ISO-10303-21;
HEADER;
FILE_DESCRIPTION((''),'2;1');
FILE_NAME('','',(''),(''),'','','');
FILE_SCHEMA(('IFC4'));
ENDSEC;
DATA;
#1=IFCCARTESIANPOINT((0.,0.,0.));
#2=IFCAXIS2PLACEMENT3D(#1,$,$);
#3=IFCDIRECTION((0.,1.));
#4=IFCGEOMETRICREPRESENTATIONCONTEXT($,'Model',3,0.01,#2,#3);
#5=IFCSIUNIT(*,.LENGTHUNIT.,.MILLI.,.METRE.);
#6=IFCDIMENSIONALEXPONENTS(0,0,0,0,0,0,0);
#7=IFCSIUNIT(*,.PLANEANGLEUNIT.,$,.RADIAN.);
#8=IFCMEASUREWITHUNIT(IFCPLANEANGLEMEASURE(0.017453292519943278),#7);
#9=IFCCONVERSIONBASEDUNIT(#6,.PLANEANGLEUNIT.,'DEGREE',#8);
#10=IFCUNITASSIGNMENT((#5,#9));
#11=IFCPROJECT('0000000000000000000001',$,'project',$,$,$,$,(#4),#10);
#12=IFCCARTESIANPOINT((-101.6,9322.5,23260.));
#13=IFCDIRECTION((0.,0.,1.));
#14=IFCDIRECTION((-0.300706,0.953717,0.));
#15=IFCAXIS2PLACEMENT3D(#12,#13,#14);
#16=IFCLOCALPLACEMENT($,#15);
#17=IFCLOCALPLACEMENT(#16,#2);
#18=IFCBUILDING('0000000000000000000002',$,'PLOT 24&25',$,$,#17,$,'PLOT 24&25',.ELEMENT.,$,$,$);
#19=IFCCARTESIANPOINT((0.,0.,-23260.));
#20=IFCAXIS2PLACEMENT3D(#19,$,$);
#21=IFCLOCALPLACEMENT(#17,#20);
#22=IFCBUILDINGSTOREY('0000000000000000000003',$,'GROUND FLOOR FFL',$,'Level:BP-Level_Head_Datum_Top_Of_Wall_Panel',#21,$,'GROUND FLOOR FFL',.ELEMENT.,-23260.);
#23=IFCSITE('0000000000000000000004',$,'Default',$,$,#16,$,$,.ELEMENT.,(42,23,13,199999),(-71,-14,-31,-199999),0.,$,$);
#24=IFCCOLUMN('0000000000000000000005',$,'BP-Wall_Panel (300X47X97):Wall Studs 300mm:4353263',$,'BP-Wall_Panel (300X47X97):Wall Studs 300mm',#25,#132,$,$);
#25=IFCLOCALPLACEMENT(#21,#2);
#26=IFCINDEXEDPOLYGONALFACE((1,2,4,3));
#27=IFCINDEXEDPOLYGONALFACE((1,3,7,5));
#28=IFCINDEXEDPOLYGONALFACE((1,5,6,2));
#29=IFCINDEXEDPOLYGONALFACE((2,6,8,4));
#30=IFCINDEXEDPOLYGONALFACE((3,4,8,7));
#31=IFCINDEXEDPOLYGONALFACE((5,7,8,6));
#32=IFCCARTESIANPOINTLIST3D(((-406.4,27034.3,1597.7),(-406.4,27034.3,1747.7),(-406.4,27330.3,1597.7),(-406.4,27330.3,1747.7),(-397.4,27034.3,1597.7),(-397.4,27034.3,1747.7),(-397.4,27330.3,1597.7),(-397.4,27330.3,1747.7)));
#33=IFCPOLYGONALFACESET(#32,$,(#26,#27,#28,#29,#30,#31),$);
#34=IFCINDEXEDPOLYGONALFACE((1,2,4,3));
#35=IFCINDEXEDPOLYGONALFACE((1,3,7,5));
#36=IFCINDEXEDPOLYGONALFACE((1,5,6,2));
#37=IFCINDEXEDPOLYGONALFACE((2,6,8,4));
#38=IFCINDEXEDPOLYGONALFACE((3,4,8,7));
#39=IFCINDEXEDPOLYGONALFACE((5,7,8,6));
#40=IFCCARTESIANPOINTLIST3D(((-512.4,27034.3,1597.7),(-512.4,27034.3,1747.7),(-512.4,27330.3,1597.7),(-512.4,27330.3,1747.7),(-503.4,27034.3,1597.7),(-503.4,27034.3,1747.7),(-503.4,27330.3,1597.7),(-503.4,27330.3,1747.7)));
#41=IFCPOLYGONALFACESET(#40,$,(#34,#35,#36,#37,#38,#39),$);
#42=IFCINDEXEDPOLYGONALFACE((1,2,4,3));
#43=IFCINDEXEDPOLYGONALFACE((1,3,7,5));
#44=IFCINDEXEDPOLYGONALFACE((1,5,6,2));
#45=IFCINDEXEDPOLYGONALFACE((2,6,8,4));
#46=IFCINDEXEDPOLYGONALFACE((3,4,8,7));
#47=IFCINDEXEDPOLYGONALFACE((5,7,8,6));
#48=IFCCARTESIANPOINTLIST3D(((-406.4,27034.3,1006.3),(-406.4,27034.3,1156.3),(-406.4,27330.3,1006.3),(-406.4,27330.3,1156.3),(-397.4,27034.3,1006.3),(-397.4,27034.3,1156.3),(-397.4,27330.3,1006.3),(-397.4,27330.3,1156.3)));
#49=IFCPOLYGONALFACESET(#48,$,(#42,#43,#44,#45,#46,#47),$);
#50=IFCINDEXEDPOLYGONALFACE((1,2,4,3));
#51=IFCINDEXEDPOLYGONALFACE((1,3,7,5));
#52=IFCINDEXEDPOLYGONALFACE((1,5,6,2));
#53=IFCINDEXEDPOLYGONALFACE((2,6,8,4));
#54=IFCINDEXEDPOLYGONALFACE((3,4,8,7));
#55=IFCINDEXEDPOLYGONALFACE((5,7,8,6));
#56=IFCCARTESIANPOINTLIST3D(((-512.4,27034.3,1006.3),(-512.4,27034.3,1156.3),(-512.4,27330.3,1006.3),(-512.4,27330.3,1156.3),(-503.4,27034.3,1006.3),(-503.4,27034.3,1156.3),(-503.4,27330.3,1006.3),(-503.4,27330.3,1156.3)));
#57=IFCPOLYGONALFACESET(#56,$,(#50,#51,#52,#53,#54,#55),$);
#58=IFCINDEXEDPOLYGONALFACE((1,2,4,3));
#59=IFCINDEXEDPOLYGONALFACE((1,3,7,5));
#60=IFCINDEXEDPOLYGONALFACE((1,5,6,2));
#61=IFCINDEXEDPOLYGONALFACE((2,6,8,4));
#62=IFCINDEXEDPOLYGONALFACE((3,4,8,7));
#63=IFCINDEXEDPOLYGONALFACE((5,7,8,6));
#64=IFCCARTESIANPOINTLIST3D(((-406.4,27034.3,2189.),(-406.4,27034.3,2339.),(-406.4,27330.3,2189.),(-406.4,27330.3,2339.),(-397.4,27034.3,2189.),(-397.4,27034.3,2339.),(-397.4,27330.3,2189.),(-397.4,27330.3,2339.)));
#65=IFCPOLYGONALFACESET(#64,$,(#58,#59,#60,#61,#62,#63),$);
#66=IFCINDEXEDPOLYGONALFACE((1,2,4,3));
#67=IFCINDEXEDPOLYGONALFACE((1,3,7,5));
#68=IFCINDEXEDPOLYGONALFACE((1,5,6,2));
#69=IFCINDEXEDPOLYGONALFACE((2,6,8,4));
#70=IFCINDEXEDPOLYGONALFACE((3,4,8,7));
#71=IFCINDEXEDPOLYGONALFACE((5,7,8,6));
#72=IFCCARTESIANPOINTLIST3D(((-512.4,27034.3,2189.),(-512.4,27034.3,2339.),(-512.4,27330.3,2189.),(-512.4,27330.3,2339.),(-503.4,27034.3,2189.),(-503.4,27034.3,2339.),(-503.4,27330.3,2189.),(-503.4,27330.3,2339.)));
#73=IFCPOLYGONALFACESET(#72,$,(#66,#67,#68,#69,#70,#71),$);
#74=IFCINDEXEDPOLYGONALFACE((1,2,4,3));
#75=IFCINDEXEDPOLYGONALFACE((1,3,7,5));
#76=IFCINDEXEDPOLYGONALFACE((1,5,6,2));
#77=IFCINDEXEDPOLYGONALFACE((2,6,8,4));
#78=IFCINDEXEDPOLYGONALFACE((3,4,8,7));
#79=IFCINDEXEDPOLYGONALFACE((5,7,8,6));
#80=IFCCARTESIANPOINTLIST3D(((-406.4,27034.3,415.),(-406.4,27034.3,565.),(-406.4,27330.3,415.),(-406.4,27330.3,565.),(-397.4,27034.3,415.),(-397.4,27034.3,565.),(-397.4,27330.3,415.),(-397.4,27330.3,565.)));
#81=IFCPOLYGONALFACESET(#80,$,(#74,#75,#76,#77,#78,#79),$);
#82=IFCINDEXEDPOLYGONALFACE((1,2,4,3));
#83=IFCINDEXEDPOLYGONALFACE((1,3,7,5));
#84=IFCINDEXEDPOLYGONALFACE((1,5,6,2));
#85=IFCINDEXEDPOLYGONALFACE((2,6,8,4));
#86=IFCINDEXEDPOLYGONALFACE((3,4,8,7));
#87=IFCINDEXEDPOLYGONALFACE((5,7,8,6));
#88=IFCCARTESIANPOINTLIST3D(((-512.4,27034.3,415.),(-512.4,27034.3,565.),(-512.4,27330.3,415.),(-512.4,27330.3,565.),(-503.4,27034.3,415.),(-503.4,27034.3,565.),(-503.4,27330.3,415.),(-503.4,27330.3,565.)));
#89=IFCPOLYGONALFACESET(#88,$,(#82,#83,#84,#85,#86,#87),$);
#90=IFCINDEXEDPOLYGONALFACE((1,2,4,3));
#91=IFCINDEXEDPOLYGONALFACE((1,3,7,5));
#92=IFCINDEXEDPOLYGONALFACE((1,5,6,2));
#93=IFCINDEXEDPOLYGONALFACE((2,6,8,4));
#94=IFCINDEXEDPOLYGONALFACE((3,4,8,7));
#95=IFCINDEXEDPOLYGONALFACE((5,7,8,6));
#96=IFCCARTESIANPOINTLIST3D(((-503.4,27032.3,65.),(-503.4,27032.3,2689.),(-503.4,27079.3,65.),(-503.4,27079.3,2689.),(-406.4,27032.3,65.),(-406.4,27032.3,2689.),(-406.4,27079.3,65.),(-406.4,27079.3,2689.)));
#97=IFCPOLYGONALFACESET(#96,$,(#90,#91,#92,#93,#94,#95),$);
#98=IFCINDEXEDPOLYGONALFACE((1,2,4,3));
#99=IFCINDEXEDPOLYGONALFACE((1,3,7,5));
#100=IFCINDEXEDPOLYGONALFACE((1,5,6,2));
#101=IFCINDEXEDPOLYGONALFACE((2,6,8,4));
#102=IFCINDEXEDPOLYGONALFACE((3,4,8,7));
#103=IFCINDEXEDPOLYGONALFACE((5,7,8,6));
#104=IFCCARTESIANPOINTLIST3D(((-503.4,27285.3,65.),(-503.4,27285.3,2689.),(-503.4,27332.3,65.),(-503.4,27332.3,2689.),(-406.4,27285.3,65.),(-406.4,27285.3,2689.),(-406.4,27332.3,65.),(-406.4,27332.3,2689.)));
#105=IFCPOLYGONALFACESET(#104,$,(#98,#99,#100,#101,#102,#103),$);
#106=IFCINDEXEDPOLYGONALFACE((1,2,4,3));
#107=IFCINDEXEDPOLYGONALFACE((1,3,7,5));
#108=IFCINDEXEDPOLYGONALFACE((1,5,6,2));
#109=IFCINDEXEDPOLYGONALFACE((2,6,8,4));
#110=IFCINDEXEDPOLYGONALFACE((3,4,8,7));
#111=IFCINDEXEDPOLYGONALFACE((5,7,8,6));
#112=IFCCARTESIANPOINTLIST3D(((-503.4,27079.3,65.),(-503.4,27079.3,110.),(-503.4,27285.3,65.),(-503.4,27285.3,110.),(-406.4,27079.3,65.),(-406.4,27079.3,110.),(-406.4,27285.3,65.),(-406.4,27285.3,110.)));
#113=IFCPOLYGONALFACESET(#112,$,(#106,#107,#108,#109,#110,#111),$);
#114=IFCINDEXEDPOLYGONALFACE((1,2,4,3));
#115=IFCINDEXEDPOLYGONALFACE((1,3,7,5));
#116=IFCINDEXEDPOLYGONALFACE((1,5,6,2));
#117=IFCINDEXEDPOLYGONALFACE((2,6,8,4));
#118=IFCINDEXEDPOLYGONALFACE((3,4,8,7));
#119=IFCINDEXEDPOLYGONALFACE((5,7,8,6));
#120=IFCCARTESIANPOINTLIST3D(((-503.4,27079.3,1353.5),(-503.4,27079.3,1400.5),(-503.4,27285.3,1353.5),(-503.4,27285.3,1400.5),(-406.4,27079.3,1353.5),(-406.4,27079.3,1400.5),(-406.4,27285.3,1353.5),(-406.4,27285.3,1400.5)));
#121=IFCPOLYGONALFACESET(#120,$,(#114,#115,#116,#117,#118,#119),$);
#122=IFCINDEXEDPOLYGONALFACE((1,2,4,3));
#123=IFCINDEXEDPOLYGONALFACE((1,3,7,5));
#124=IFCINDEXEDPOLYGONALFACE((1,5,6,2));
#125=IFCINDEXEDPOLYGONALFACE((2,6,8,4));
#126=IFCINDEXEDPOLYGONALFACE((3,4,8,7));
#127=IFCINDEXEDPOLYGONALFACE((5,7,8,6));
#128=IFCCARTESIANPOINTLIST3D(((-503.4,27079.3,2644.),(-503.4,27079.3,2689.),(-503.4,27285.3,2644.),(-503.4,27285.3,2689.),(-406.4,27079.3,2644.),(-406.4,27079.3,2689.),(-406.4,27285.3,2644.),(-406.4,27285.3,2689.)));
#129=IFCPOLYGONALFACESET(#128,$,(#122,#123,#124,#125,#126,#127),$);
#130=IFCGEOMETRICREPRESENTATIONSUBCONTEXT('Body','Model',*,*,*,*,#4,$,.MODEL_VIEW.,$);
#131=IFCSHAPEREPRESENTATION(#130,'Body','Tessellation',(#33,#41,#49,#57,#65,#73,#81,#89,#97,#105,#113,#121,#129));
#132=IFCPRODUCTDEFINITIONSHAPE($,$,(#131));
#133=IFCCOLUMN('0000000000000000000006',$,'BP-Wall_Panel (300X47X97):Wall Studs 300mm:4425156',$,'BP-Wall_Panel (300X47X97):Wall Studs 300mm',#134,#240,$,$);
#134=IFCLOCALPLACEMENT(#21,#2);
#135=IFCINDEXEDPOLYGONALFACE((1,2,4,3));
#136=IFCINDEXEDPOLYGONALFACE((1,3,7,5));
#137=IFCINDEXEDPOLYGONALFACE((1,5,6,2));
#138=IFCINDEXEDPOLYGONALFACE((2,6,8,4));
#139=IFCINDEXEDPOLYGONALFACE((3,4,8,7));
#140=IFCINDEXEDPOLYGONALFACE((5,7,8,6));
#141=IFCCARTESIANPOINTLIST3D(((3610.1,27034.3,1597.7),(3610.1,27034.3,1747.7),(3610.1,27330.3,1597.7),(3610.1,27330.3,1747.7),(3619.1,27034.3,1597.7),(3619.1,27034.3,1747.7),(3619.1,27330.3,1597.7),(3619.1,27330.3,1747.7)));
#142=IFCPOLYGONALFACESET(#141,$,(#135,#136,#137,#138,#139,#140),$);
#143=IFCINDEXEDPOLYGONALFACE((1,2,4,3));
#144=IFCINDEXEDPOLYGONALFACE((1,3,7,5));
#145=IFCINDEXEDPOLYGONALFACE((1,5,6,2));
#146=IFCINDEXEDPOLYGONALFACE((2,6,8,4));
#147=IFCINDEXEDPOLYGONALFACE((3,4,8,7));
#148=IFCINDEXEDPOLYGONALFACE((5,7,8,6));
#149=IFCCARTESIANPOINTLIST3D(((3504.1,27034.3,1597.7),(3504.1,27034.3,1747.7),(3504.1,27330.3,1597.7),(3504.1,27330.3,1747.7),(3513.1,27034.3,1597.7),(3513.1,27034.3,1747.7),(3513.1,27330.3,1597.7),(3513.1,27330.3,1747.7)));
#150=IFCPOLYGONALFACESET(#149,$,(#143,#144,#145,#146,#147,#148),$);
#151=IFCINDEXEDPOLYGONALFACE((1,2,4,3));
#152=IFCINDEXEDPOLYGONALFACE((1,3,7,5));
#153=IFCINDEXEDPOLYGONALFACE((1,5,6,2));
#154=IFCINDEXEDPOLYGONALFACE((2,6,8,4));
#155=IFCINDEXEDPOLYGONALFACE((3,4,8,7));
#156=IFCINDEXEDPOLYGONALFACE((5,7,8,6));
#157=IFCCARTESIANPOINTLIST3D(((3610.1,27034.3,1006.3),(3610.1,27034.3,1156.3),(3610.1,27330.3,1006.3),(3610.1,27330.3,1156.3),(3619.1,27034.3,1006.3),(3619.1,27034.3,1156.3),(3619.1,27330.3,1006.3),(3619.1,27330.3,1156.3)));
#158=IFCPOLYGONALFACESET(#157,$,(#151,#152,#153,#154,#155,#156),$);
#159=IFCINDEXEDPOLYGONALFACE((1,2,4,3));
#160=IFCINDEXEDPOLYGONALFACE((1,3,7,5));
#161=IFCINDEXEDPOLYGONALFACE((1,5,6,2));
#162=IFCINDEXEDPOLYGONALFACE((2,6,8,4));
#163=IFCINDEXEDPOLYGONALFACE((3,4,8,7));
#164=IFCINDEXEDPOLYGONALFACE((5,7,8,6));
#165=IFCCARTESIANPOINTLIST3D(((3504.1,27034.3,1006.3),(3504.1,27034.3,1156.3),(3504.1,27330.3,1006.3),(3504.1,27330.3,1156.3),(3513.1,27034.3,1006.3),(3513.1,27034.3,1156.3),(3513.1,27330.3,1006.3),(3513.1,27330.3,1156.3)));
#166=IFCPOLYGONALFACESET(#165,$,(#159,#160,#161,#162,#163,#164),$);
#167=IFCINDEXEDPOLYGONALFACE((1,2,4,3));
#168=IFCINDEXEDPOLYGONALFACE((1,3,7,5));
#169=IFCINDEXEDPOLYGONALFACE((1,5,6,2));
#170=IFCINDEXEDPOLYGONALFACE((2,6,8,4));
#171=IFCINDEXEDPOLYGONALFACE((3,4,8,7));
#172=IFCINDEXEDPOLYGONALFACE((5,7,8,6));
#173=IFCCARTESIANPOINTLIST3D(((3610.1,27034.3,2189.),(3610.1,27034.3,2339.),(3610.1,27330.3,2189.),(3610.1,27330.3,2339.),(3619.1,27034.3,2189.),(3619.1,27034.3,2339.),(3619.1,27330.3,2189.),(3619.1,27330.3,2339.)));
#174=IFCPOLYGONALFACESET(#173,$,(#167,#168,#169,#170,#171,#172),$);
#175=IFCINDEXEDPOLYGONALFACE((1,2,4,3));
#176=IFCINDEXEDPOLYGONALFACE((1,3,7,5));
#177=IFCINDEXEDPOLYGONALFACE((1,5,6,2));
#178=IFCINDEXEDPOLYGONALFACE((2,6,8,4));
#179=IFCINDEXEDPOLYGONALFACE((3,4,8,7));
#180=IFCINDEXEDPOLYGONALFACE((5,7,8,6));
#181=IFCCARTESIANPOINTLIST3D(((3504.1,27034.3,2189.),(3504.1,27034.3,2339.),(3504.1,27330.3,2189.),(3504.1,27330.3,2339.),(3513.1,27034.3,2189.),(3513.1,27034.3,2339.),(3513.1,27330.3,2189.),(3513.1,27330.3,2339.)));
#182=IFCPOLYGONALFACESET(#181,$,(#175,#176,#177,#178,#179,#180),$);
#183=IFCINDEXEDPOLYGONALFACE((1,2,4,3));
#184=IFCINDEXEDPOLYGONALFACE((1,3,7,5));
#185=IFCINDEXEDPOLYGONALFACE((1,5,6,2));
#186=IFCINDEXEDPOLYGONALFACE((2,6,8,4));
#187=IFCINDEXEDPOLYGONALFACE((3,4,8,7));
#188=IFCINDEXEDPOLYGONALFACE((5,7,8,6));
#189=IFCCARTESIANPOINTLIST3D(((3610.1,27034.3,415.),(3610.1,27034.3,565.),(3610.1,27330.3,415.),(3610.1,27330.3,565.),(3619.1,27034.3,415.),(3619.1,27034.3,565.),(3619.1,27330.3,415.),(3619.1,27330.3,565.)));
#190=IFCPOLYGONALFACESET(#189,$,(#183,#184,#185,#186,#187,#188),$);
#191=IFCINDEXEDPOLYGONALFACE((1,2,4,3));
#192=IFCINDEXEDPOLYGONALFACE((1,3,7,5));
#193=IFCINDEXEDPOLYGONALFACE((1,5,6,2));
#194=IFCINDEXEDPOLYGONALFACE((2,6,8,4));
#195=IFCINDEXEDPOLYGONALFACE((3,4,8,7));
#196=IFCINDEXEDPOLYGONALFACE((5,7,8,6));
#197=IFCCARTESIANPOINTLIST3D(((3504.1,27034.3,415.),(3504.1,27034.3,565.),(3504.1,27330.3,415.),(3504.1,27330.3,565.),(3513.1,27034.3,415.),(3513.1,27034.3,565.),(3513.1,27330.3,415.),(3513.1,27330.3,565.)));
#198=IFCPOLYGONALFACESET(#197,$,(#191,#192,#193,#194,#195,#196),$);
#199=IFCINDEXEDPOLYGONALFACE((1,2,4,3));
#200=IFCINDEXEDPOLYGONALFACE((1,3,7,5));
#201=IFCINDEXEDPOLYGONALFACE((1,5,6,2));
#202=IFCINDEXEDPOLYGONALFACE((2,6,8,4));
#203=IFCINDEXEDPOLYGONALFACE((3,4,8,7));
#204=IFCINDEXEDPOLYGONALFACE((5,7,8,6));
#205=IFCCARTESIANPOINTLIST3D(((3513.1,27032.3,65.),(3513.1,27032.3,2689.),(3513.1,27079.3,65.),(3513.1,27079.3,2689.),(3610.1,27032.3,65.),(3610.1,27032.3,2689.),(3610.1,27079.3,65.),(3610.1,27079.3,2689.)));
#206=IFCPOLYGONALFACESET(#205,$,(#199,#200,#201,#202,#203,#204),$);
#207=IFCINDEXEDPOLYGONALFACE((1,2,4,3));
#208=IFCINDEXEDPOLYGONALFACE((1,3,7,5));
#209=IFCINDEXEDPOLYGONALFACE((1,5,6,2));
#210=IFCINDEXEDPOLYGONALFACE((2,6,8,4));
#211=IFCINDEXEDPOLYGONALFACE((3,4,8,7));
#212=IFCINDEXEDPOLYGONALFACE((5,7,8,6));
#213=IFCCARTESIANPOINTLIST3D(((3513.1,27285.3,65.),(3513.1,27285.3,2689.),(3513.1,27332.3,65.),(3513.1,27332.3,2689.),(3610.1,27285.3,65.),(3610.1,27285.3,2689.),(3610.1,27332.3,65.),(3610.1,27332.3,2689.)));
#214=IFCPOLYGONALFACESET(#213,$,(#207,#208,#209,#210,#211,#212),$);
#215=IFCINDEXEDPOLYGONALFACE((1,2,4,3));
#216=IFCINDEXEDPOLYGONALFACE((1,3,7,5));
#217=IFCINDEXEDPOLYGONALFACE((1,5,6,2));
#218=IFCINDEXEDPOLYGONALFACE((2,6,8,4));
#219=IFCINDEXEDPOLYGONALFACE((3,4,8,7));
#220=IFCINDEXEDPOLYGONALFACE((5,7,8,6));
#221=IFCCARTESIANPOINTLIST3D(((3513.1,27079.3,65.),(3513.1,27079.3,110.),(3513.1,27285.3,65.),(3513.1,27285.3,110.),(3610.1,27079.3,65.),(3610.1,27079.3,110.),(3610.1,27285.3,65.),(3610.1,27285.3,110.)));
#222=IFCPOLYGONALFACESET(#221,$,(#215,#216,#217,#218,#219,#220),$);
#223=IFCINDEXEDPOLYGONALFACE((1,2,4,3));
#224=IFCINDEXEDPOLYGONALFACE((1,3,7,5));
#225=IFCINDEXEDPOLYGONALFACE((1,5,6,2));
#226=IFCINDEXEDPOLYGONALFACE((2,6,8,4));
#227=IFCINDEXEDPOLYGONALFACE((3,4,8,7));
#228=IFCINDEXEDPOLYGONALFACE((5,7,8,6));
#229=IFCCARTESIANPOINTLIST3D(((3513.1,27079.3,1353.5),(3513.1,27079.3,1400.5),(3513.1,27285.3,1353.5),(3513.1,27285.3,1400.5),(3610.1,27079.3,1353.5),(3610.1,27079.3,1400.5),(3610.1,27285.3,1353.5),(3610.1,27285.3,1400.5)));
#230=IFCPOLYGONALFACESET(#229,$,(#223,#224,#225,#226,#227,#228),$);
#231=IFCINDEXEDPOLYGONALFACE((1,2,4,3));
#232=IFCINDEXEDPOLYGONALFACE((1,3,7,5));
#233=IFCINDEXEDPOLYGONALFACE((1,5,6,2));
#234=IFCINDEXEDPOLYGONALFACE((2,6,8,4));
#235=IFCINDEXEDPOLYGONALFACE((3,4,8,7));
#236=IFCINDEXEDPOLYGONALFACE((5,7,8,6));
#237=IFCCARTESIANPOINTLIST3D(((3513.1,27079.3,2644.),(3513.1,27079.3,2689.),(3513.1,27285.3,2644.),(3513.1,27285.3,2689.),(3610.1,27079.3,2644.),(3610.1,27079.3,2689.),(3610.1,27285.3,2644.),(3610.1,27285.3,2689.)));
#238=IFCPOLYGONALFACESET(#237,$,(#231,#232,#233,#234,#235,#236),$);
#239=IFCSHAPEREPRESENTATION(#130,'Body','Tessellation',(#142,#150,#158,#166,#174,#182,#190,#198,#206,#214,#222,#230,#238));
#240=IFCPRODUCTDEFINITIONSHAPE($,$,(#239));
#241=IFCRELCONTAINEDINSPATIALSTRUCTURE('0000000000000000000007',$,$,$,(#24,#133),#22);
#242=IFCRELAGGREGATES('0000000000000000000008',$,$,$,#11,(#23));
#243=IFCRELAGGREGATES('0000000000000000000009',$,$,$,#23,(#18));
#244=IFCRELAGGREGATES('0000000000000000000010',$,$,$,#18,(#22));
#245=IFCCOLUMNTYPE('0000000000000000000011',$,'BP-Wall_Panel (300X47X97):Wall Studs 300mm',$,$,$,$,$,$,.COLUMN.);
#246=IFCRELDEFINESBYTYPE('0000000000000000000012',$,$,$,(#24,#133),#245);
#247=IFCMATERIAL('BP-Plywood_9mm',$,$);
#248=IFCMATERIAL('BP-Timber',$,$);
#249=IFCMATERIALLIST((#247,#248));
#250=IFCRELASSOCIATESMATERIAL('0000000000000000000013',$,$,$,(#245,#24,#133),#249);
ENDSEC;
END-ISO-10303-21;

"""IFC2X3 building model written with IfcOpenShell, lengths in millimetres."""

from ifc_helpers import new_model, entity, si_unit, converted_unit, direction, frame, frame_2d, origin, origin_2d_with_axis, place, context, subcontext, project, spatial, rectangle, extrude, source, transform, mapped, material, material_list, type_object, type_shapes, element, save


model = new_model("IFC2X3")

# Units and contexts
model_context = context("Model", 3, precision=0.01, world=origin(), true_north=direction((0.0, 1.0)))
body_context = subcontext(model_context, "Body", "Model", "MODEL_VIEW")
ifc_project = project(units=[si_unit("LENGTHUNIT", "METRE", prefix="MILLI"), converted_unit("PLANEANGLEUNIT", "DEGREE", entity("IfcPlaneAngleMeasure", 0.017453292519943278), si_unit("PLANEANGLEUNIT", "RADIAN"), dimensions=[0, 0, 0, 0, 0, 0, 0])], contexts=[model_context])

# Site, building, storey
site_placement = place(None, frame((-101.6, 9322.5, 23260.0), z_axis=(0.0, 0.0, 1.0), x_axis=(-0.300706, 0.953717, 0.0)))
site = spatial("IfcSite", under=ifc_project, at=site_placement, Name="Default", CompositionType="ELEMENT", RefLatitude=(42, 23, 13, 199999), RefLongitude=(-71, -14, -31, -199999), RefElevation=0.0)
building_placement = place(site_placement, origin())
building = spatial("IfcBuilding", under=site, at=building_placement, Name="PLOT 24&25", LongName="PLOT 24&25", CompositionType="ELEMENT")
storey_placement = place(building_placement, frame((0.0, 0.0, -23260.0)))
storey = spatial("IfcBuildingStorey", under=building, at=storey_placement, Name="GROUND FLOOR FFL", ObjectType="Level:BP-Level_Head_Datum_Top_Of_Wall_Panel", LongName="GROUND FLOOR FFL", CompositionType="ELEMENT", Elevation=-23260.0)

# Columns
ifc_material_1 = material(Name="BP-Plywood_9mm")
ifc_material_2 = material(Name="BP-Timber")
ifc_material_list = material_list([ifc_material_1, ifc_material_2])
column_type_1 = type_object("IfcColumnType", Name="BP-Wall_Panel (300X47X97):Wall Studs 300mm", PredefinedType="COLUMN", material=ifc_material_list)
shared_shape_1 = source(origin(), body_context, "Body", "SweptSolid", [
    extrude(rectangle(XDim=296.0, YDim=9.0, at=origin_2d_with_axis()), frame((53.0, 0.0, -21662.3), z_axis=(0.0, 0.0, 1.0), x_axis=(0.0, -1.0, 0.0)), (0.0, 0.0, 1.0), 150.0),
    extrude(rectangle(XDim=9.0, YDim=296.0, at=origin_2d_with_axis()), frame((-53.0, 0.0, -21662.3), z_axis=(0.0, 0.0, 1.0), x_axis=(-1.0, 0.0, 0.0)), (0.0, 0.0, 1.0), 150.0),
    extrude(rectangle(XDim=296.0, YDim=9.0, at=origin_2d_with_axis()), frame((53.0, 0.0, -22253.7), z_axis=(0.0, 0.0, 1.0), x_axis=(0.0, -1.0, 0.0)), (0.0, 0.0, 1.0), 150.0),
    extrude(rectangle(XDim=9.0, YDim=296.0, at=origin_2d_with_axis()), frame((-53.0, 0.0, -22253.7), z_axis=(0.0, 0.0, 1.0), x_axis=(-1.0, 0.0, 0.0)), (0.0, 0.0, 1.0), 150.0),
    extrude(rectangle(XDim=296.0, YDim=9.0, at=origin_2d_with_axis()), frame((53.0, 0.0, -21071.0), z_axis=(0.0, 0.0, 1.0), x_axis=(0.0, -1.0, 0.0)), (0.0, 0.0, 1.0), 150.0),
    extrude(rectangle(XDim=9.0, YDim=296.0, at=origin_2d_with_axis()), frame((-53.0, 0.0, -21071.0), z_axis=(0.0, 0.0, 1.0), x_axis=(-1.0, 0.0, 0.0)), (0.0, 0.0, 1.0), 150.0),
    extrude(rectangle(XDim=296.0, YDim=9.0, at=origin_2d_with_axis()), frame((53.0, 0.0, -22845.0), z_axis=(0.0, 0.0, 1.0), x_axis=(0.0, -1.0, 0.0)), (0.0, 0.0, 1.0), 150.0),
    extrude(rectangle(XDim=9.0, YDim=296.0, at=origin_2d_with_axis()), frame((-53.0, 0.0, -22845.0), z_axis=(0.0, 0.0, 1.0), x_axis=(-1.0, 0.0, 0.0)), (0.0, 0.0, 1.0), 150.0),
    extrude(rectangle(XDim=97.0, YDim=47.0, at=origin_2d_with_axis()), frame((0.0, -126.5, -23195.0), z_axis=(0.0, 0.0, 1.0), x_axis=(-1.0, 0.0, 0.0)), (0.0, 0.0, 1.0), 2624.0),
    extrude(rectangle(XDim=97.0, YDim=47.0, at=frame_2d((0.0, 0.0), x_axis=(1.0, 0.0))), frame((0.0, 126.5, -23195.0), z_axis=(0.0, 0.0, 1.0), x_axis=(-1.0, 0.0, 0.0)), (0.0, 0.0, 1.0), 2624.0),
    extrude(rectangle(XDim=206.0, YDim=97.0, at=origin_2d_with_axis()), frame((0.0, 0.0, -23195.0), z_axis=(0.0, 0.0, 1.0), x_axis=(0.0, -1.0, 0.0)), (0.0, 0.0, 1.0), 45.0),
    extrude(rectangle(XDim=206.0, YDim=97.0, at=origin_2d_with_axis()), frame((0.0, 0.0, -21906.5), z_axis=(0.0, 0.0, 1.0), x_axis=(0.0, -1.0, 0.0)), (0.0, 0.0, 1.0), 47.0),
    extrude(rectangle(XDim=206.0, YDim=97.0, at=origin_2d_with_axis()), frame((0.0, 0.0, -20616.0), z_axis=(0.0, 0.0, 1.0), x_axis=(0.0, -1.0, 0.0)), (0.0, 0.0, 1.0), 45.0),
])
type_shapes(column_type_1, [shared_shape_1])
for number, where, name in (
    (1, (-454.9, 27182.3, 23260.0), "BP-Wall_Panel (300X47X97):Wall Studs 300mm:4353263"),
    (2, (3561.6, 27182.3, 23260.0), "BP-Wall_Panel (300X47X97):Wall Studs 300mm:4425156"),
):
    element("IfcColumn", number, at=place(storey_placement, frame(where)), inside=storey, type_object=column_type_1, material=ifc_material_list, Name=name, ObjectType="BP-Wall_Panel (300X47X97):Wall Studs 300mm", context=body_context, shape_type="MappedRepresentation", body=[
        mapped(shared_shape_1, transform((0.0, 0.0, 0.0), scale=1.0)),
    ])

save(model, "model.ifc")
